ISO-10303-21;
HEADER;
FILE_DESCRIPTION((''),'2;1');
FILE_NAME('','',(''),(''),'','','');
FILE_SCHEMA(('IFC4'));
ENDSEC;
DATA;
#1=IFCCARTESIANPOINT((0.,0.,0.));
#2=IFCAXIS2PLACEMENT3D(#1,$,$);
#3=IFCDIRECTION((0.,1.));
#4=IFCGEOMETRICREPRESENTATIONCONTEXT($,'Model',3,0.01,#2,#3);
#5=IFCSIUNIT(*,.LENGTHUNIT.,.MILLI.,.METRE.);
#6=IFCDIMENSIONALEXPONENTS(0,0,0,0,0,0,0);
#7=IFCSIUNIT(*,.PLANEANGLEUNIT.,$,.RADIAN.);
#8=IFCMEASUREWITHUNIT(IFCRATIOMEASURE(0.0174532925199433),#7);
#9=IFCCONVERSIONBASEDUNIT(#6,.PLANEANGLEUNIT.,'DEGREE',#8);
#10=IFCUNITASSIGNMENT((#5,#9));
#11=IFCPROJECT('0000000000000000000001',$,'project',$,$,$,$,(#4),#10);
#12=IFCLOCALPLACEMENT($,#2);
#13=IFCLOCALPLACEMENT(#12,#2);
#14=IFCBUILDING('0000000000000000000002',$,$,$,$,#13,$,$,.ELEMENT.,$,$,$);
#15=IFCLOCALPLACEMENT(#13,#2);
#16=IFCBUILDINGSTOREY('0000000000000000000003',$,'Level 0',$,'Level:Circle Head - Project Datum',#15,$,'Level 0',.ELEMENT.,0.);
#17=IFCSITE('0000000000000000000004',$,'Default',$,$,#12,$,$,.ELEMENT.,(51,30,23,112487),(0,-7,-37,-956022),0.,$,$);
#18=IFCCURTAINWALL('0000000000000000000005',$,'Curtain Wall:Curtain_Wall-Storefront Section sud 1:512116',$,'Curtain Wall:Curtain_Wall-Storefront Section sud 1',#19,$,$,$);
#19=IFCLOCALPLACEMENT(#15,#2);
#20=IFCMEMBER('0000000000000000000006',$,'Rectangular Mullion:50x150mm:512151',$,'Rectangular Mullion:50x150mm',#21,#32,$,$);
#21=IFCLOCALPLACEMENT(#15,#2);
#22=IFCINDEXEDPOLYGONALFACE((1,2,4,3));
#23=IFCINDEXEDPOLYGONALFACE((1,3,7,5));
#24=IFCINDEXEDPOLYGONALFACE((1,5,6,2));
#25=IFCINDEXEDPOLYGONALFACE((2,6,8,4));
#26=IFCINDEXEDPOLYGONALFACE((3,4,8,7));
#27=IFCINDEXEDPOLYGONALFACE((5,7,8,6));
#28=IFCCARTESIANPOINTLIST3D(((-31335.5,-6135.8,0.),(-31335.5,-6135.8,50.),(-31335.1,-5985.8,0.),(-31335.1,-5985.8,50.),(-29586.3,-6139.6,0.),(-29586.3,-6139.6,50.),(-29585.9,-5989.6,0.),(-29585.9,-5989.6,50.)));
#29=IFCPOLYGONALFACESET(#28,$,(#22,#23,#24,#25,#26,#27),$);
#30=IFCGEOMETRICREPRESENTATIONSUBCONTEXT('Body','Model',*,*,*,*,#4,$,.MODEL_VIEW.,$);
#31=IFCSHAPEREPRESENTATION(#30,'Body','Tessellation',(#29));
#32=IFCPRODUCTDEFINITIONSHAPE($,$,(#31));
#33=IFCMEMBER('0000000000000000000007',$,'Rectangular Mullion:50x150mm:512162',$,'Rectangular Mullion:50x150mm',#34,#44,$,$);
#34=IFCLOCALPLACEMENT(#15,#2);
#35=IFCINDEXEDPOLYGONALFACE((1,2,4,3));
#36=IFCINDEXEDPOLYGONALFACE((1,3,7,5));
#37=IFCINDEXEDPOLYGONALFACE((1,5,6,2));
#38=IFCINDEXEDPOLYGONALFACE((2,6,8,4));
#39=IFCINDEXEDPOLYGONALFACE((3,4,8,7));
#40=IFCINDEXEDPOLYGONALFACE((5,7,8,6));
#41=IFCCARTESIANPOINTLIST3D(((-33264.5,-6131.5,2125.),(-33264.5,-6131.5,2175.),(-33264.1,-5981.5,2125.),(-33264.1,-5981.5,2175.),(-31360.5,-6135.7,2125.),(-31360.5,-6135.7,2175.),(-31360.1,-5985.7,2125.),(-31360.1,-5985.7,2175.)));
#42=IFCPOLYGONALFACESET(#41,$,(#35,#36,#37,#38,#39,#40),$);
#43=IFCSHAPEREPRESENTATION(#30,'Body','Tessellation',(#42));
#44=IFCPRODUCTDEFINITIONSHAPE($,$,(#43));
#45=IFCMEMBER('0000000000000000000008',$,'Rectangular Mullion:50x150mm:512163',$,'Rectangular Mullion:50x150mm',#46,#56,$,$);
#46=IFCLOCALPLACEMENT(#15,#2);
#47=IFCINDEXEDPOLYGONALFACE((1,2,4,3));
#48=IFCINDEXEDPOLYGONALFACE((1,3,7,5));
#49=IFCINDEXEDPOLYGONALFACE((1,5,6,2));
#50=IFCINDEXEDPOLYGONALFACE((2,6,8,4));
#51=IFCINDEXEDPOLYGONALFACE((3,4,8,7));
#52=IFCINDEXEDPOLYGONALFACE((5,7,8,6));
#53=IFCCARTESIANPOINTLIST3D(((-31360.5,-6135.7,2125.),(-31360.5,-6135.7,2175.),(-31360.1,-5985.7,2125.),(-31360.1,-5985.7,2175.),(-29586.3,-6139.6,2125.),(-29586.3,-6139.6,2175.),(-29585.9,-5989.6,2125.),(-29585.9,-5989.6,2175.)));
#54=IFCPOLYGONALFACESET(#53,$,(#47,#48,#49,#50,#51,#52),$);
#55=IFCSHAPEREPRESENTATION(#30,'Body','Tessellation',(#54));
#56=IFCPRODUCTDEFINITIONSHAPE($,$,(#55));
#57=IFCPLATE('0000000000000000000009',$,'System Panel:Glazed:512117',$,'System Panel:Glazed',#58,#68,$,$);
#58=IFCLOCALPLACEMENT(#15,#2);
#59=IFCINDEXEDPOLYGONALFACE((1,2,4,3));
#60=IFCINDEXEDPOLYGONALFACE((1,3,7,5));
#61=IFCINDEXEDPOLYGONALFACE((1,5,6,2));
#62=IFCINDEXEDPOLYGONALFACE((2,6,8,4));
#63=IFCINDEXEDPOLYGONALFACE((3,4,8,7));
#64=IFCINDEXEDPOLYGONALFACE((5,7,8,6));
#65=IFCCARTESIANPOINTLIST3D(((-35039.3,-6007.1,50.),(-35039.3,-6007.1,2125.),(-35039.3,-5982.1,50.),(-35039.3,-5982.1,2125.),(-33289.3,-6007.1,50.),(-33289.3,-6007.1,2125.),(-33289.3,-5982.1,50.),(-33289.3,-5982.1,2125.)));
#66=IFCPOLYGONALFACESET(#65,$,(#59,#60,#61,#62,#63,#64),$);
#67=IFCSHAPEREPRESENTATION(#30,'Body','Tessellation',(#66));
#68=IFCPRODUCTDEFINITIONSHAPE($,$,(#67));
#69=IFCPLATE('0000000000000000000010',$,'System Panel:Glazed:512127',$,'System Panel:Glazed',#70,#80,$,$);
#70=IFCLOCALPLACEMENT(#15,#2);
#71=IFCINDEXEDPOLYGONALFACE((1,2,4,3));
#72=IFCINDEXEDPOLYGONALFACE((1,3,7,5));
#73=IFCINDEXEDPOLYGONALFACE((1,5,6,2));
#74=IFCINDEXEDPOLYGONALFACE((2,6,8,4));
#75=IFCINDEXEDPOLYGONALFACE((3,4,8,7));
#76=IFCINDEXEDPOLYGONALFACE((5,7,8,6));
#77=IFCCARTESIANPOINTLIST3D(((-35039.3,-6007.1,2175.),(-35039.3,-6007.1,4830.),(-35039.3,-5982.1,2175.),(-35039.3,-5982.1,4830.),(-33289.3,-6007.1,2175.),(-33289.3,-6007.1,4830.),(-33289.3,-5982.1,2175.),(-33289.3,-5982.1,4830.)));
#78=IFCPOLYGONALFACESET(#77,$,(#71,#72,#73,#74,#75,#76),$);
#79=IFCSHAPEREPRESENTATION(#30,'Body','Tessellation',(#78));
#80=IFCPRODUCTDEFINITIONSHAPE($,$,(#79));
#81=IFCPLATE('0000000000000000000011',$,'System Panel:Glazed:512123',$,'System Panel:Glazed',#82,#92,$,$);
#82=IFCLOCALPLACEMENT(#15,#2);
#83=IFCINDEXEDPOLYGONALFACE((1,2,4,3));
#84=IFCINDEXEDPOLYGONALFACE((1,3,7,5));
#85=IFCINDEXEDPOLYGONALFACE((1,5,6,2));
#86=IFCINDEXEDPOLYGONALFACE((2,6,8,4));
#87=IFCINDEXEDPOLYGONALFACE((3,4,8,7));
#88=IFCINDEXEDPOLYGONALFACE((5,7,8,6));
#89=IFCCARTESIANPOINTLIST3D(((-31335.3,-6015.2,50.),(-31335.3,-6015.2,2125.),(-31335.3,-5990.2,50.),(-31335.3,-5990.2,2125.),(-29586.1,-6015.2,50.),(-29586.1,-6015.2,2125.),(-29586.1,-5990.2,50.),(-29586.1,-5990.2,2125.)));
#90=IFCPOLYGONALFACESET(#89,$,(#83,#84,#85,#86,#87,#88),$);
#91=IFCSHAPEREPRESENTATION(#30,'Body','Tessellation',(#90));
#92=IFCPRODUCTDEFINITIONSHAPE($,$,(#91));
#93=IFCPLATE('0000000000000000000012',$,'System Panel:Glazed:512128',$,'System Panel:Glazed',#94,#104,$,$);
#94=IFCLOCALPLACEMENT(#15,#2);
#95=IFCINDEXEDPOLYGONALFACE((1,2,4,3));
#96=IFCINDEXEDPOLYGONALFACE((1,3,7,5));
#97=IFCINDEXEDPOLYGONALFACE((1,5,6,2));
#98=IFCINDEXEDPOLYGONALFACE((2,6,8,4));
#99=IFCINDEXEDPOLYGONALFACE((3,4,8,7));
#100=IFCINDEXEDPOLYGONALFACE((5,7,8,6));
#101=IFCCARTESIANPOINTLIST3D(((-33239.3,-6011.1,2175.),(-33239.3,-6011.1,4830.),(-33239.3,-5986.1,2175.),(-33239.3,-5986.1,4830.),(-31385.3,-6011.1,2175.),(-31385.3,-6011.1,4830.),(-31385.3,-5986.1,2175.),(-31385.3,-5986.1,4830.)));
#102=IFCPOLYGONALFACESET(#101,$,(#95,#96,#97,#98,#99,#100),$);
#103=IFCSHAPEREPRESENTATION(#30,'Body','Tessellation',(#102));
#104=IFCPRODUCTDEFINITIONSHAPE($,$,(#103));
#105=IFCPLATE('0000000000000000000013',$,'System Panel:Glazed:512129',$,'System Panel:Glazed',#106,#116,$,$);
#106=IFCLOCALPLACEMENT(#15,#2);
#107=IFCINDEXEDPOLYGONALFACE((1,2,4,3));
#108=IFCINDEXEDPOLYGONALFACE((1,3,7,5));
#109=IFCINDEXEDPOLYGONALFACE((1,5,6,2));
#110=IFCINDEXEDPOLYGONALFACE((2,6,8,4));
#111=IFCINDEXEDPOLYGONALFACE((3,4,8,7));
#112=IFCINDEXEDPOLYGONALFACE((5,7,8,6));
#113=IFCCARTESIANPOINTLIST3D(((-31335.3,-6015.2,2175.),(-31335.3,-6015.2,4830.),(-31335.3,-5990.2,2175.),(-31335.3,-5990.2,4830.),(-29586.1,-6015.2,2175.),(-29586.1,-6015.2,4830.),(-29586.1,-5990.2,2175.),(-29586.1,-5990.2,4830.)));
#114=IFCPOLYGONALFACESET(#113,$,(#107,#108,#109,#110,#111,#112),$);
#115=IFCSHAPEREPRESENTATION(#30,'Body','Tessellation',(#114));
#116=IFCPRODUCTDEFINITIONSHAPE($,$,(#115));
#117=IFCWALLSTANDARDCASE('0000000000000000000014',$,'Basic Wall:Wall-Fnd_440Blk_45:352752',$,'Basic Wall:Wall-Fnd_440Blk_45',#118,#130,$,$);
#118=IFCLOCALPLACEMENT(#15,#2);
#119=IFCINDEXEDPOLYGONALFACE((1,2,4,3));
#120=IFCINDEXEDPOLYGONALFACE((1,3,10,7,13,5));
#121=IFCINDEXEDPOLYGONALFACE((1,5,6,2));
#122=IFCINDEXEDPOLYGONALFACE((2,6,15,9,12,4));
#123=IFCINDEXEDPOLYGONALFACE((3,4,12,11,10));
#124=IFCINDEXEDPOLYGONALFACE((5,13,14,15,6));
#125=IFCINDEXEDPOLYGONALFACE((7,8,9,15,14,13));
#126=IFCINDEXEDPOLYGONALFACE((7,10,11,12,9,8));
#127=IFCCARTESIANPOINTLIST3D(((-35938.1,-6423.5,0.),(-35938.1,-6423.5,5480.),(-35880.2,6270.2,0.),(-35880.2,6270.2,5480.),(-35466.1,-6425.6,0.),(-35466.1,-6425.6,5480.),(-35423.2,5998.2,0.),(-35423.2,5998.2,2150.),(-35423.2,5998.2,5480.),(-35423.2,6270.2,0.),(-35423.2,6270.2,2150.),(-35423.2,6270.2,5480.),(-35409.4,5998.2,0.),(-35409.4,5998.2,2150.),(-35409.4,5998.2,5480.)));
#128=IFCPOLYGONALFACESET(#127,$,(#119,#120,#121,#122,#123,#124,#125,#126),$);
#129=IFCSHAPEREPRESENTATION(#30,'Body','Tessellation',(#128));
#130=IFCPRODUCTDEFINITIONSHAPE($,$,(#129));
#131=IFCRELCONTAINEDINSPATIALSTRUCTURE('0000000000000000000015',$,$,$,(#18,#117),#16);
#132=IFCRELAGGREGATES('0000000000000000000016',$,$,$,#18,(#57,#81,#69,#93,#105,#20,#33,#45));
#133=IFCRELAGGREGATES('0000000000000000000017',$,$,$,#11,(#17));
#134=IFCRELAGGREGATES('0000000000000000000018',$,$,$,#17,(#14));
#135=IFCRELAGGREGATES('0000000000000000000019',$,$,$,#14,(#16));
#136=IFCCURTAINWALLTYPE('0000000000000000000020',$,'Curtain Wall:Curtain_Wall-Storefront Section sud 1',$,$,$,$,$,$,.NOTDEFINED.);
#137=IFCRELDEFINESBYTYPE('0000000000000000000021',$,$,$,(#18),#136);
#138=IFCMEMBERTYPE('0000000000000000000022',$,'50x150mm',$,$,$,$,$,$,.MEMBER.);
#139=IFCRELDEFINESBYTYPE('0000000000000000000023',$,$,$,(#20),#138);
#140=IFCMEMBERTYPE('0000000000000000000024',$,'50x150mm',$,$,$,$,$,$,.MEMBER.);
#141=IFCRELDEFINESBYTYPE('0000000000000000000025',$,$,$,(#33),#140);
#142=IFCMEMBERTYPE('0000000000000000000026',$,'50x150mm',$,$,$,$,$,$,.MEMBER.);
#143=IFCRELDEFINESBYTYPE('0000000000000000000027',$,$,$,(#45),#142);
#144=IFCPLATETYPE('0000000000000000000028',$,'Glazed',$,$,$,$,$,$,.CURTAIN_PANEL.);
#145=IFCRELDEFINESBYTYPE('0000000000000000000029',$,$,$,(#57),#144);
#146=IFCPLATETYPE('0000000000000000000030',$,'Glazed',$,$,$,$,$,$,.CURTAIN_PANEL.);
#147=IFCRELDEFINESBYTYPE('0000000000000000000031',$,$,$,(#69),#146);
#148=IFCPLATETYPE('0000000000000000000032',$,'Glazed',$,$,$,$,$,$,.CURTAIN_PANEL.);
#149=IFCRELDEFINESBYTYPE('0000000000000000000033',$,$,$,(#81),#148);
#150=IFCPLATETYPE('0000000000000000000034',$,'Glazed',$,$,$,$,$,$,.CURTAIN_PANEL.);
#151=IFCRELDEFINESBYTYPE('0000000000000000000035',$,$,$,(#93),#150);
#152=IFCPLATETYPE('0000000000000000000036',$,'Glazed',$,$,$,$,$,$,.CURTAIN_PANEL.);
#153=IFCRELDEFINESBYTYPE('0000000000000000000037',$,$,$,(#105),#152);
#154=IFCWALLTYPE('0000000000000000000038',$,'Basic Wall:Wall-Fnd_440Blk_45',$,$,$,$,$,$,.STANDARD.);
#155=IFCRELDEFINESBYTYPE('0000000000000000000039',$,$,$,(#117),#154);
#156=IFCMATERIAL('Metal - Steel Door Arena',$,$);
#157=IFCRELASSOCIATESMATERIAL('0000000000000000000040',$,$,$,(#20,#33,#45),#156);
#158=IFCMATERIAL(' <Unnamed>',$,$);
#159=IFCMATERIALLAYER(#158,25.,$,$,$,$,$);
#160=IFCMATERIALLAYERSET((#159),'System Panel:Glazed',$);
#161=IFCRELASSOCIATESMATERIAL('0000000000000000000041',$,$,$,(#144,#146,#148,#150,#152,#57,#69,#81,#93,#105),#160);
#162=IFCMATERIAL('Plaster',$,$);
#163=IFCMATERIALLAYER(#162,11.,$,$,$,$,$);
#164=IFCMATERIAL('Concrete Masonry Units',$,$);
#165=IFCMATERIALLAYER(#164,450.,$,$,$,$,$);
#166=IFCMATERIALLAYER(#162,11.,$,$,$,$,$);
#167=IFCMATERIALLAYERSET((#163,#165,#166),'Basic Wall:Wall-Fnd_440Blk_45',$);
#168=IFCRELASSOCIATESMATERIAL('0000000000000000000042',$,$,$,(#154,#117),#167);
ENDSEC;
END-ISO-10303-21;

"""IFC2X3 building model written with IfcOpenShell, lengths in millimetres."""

from ifc_helpers import new_model, entity, si_unit, converted_unit, direction, frame, frame_2d, origin, origin_2d_with_axis, place, context, subcontext, project, spatial, polyline, rectangle, outline, extrude, source, transform, mapped, material, layer, layer_set, layer_usage, type_object, type_shapes, element, aggregate, save


model = new_model("IFC2X3")

# Units and contexts
model_context = context("Model", 3, precision=0.01, world=origin(), true_north=direction((0.0, 1.0)))
body_context = subcontext(model_context, "Body", "Model", "MODEL_VIEW")
ifc_project = project(units=[si_unit("LENGTHUNIT", "METRE", prefix="MILLI"), converted_unit("PLANEANGLEUNIT", "DEGREE", entity("IfcRatioMeasure", 0.0174532925199433), si_unit("PLANEANGLEUNIT", "RADIAN"), dimensions=[0, 0, 0, 0, 0, 0, 0])], contexts=[model_context])

# Site, building, storey
site_placement = place(None, origin())
site = spatial("IfcSite", under=ifc_project, at=site_placement, Name="Default", CompositionType="ELEMENT", RefLatitude=(51, 30, 23, 112487), RefLongitude=(0, -7, -37, -956022), RefElevation=0.0)
building_placement = place(site_placement, origin())
building = spatial("IfcBuilding", under=site, at=building_placement, CompositionType="ELEMENT")
storey_placement = place(building_placement, origin())
storey = spatial("IfcBuildingStorey", under=building, at=storey_placement, Name="Level 0", ObjectType="Level:Circle Head - Project Datum", LongName="Level 0", CompositionType="ELEMENT", Elevation=0.0)

# Curtain wall, members, plates
curtain_wall_type = type_object("IfcCurtainWallType", Name="Curtain Wall:Curtain_Wall-Storefront Section sud 1", PredefinedType="NOTDEFINED")
curtain_wall_placement = place(storey_placement, origin())
curtain_wall = element("IfcCurtainWall", 1, at=curtain_wall_placement, inside=storey, type_object=curtain_wall_type, Name="Curtain Wall:Curtain_Wall-Storefront Section sud 1:512116", ObjectType="Curtain Wall:Curtain_Wall-Storefront Section sud 1")
ifc_material_1 = material(Name="Metal - Steel Door Arena")
member_type_1 = type_object("IfcMemberType", Name="50x150mm", PredefinedType="MEMBER")
shared_shape_1 = source(origin(), body_context, "Body", "SweptSolid", [
    extrude(rectangle(XDim=150.0, YDim=50.0, at=origin_2d_with_axis()), frame((-25.0, 0.0, -1749.2), z_axis=(0.0, 0.0, 1.0), x_axis=(0.0, -1.0, 0.0)), (0.0, 0.0, 1.0), 1749.2),
])
type_shapes(member_type_1, [shared_shape_1])
member_1_placement = place(storey_placement, frame((-31335.3, -6060.8, 0.0), z_axis=(-0.999998, 0.002199, 0.0), x_axis=(0.0, 0.0, -1.0)))
member_1 = element("IfcMember", 2, at=member_1_placement, type_object=member_type_1, material=ifc_material_1, Name="Rectangular Mullion:50x150mm:512151", ObjectType="Rectangular Mullion:50x150mm", context=body_context, shape_type="MappedRepresentation", body=[
    mapped(shared_shape_1, transform((0.0, 0.0, 0.0), scale=1.0)),
])
member_type_2 = type_object("IfcMemberType", Name="50x150mm", PredefinedType="MEMBER")
shared_shape_2 = source(origin(), body_context, "Body", "SweptSolid", [
    extrude(rectangle(XDim=150.0, YDim=50.0, at=origin_2d_with_axis()), frame((0.0, 0.0, -1904.0), z_axis=(0.0, 0.0, 1.0), x_axis=(0.0, -1.0, 0.0)), (0.0, 0.0, 1.0), 1904.0),
])
type_shapes(member_type_2, [shared_shape_2])
member_2_placement = place(storey_placement, frame((-31360.3, -6060.7, 2150.0), z_axis=(0.999998, -0.002199, 0.0), x_axis=(0.0, 0.0, 1.0)))
member_2 = element("IfcMember", 3, at=member_2_placement, type_object=member_type_2, material=ifc_material_1, Name="Rectangular Mullion:50x150mm:512162", ObjectType="Rectangular Mullion:50x150mm", context=body_context, shape_type="MappedRepresentation", body=[
    mapped(shared_shape_2, transform((0.0, 0.0, 0.0), scale=1.0)),
])
member_type_3 = type_object("IfcMemberType", Name="50x150mm", PredefinedType="MEMBER")
shared_shape_3 = source(origin(), body_context, "Body", "SweptSolid", [
    extrude(rectangle(XDim=150.0, YDim=50.0, at=origin_2d_with_axis()), frame((0.0, 0.0, -1774.2), z_axis=(0.0, 0.0, 1.0), x_axis=(0.0, -1.0, 0.0)), (0.0, 0.0, 1.0), 1774.2),
])
type_shapes(member_type_3, [shared_shape_3])
member_3_placement = place(storey_placement, frame((-29586.1, -6064.6, 2150.0), z_axis=(0.999998, -0.002199, 0.0), x_axis=(0.0, 0.0, 1.0)))
member_3 = element("IfcMember", 4, at=member_3_placement, type_object=member_type_3, material=ifc_material_1, Name="Rectangular Mullion:50x150mm:512163", ObjectType="Rectangular Mullion:50x150mm", context=body_context, shape_type="MappedRepresentation", body=[
    mapped(shared_shape_3, transform((0.0, 0.0, 0.0), scale=1.0)),
])
ifc_material_2 = material(Name=" <Unnamed>")
ifc_layer_1 = layer(ifc_material_2, 25.0)
ifc_layer_set_1 = layer_set([ifc_layer_1], Name="System Panel:Glazed")
ifc_layer_usage_1 = layer_usage(ifc_layer_set_1, "AXIS3", "POSITIVE", 0.2)
plate_type_1 = type_object("IfcPlateType", Name="Glazed", PredefinedType="CURTAIN_PANEL", material=ifc_layer_set_1)
shared_shape_4 = source(origin(), body_context, "Body", "SweptSolid", [
    extrude(rectangle(XDim=25.0, YDim=1750.0, at=origin_2d_with_axis()), frame((0.0, 60.0, 0.0), z_axis=(0.0, 0.0, 1.0), x_axis=(0.0, 1.0, 0.0)), (0.0, 0.0, 1.0), 2075.0),
])
type_shapes(plate_type_1, [shared_shape_4])
plate_1_placement = place(curtain_wall_placement, frame((-34164.3, -6054.6, 50.0)))
plate_1 = element("IfcPlate", 5, at=plate_1_placement, type_object=plate_type_1, material=ifc_layer_usage_1, Name="System Panel:Glazed:512117", ObjectType="System Panel:Glazed", context=body_context, shape_type="MappedRepresentation", body=[
    mapped(shared_shape_4, transform((0.0, 0.0, 0.0), scale=1.0)),
])
ifc_layer_usage_2 = layer_usage(ifc_layer_set_1, "AXIS3", "POSITIVE", 0.2)
plate_type_2 = type_object("IfcPlateType", Name="Glazed", PredefinedType="CURTAIN_PANEL", material=ifc_layer_set_1)
shared_shape_5 = source(origin(), body_context, "Body", "SweptSolid", [
    extrude(rectangle(XDim=25.0, YDim=1750.0, at=frame_2d((0.0, 0.0), x_axis=(1.0, 0.0))), frame((0.0, 60.0, 0.0), z_axis=(0.0, 0.0, 1.0), x_axis=(0.0, 1.0, 0.0)), (0.0, 0.0, 1.0), 2655.0),
])
type_shapes(plate_type_2, [shared_shape_5])
plate_2_placement = place(curtain_wall_placement, frame((-34164.3, -6054.6, 2175.0)))
plate_2 = element("IfcPlate", 6, at=plate_2_placement, type_object=plate_type_2, material=ifc_layer_usage_2, Name="System Panel:Glazed:512127", ObjectType="System Panel:Glazed", context=body_context, shape_type="MappedRepresentation", body=[
    mapped(shared_shape_5, transform((0.0, 0.0, 0.0), scale=1.0)),
])
ifc_layer_usage_3 = layer_usage(ifc_layer_set_1, "AXIS3", "POSITIVE", 0.2)
plate_type_3 = type_object("IfcPlateType", Name="Glazed", PredefinedType="CURTAIN_PANEL", material=ifc_layer_set_1)
shared_shape_6 = source(origin(), body_context, "Body", "SweptSolid", [
    extrude(rectangle(XDim=25.0, YDim=1749.2, at=origin_2d_with_axis()), frame((0.0, 60.0, 0.0), z_axis=(0.0, 0.0, 1.0), x_axis=(0.0, 1.0, 0.0)), (0.0, 0.0, 1.0), 2075.0),
])
type_shapes(plate_type_3, [shared_shape_6])
plate_3_placement = place(curtain_wall_placement, frame((-30460.7, -6062.7, 50.0)))
plate_3 = element("IfcPlate", 7, at=plate_3_placement, type_object=plate_type_3, material=ifc_layer_usage_3, Name="System Panel:Glazed:512123", ObjectType="System Panel:Glazed", context=body_context, shape_type="MappedRepresentation", body=[
    mapped(shared_shape_6, transform((0.0, 0.0, 0.0), scale=1.0)),
])
ifc_layer_usage_4 = layer_usage(ifc_layer_set_1, "AXIS3", "POSITIVE", 0.2)
plate_type_4 = type_object("IfcPlateType", Name="Glazed", PredefinedType="CURTAIN_PANEL", material=ifc_layer_set_1)
shared_shape_7 = source(origin(), body_context, "Body", "SweptSolid", [
    extrude(rectangle(XDim=25.0, YDim=1854.0, at=frame_2d((0.0, 0.0), x_axis=(1.0, 0.0))), frame((0.0, 60.0, 0.0), z_axis=(0.0, 0.0, 1.0), x_axis=(0.0, 1.0, 0.0)), (0.0, 0.0, 1.0), 2655.0),
])
type_shapes(plate_type_4, [shared_shape_7])
plate_4_placement = place(curtain_wall_placement, frame((-32312.3, -6058.6, 2175.0)))
plate_4 = element("IfcPlate", 8, at=plate_4_placement, type_object=plate_type_4, material=ifc_layer_usage_4, Name="System Panel:Glazed:512128", ObjectType="System Panel:Glazed", context=body_context, shape_type="MappedRepresentation", body=[
    mapped(shared_shape_7, transform((0.0, 0.0, 0.0), scale=1.0)),
])
ifc_layer_usage_5 = layer_usage(ifc_layer_set_1, "AXIS3", "POSITIVE", 0.2)
plate_type_5 = type_object("IfcPlateType", Name="Glazed", PredefinedType="CURTAIN_PANEL", material=ifc_layer_set_1)
shared_shape_8 = source(origin(), body_context, "Body", "SweptSolid", [
    extrude(rectangle(XDim=25.0, YDim=1749.2, at=frame_2d((0.0, 0.0), x_axis=(1.0, 0.0))), frame((0.0, 60.0, 0.0), z_axis=(0.0, 0.0, 1.0), x_axis=(0.0, 1.0, 0.0)), (0.0, 0.0, 1.0), 2655.0),
])
type_shapes(plate_type_5, [shared_shape_8])
plate_5_placement = place(curtain_wall_placement, frame((-30460.7, -6062.7, 2175.0)))
plate_5 = element("IfcPlate", 9, at=plate_5_placement, type_object=plate_type_5, material=ifc_layer_usage_5, Name="System Panel:Glazed:512129", ObjectType="System Panel:Glazed", context=body_context, shape_type="MappedRepresentation", body=[
    mapped(shared_shape_8, transform((0.0, 0.0, 0.0), scale=1.0)),
])
aggregate(curtain_wall, [plate_1, plate_3, plate_2, plate_4, plate_5, member_1, member_2, member_3])

# Wall, opening
ifc_material_3 = material(Name="Plaster")
ifc_layer_2 = layer(ifc_material_3, 11.0)
ifc_material_4 = material(Name="Concrete Masonry Units")
ifc_layer_3 = layer(ifc_material_4, 450.0)
ifc_layer_4 = layer(ifc_material_3, 11.0)
ifc_layer_set_2 = layer_set([ifc_layer_2, ifc_layer_3, ifc_layer_4], Name="Basic Wall:Wall-Fnd_440Blk_45")
ifc_layer_usage_6 = layer_usage(ifc_layer_set_2, "AXIS2", "NEGATIVE", 236.0)
wall_type = type_object("IfcWallType", Name="Basic Wall:Wall-Fnd_440Blk_45", PredefinedType="STANDARD", material=ifc_layer_set_2)
wall_placement = place(storey_placement, frame((-35644.2, 6271.3, 0.0), z_axis=(0.0, 0.0, 1.0), x_axis=(-0.004561, -0.99999, 0.0)))
wall = element("IfcWallStandardCase", 10, at=wall_placement, inside=storey, type_object=wall_type, material=ifc_layer_usage_6, Name="Basic Wall:Wall-Fnd_440Blk_45:352752", ObjectType="Basic Wall:Wall-Fnd_440Blk_45", context=body_context, shape_type="SweptSolid", body=[
    extrude(outline(polyline([(12696.0, -236.0), (12696.0, 236.0), (12611.6, 236.0), (12247.1, 236.0), (272.0, 236.0), (272.1, 222.2), (0.1, 221.0), (2.2, -236.0), (12696.0, -236.0)])), origin(), (0.0, 0.0, 1.0), 5480.0),
])
opening_placement = place(wall_placement, origin())
element("IfcOpeningElement", 11, at=opening_placement, cuts=wall, ObjectType="Opening", context=body_context, shape_type="SweptSolid", body=[
    extrude(rectangle(XDim=2150.0, YDim=272.0, at=frame_2d((0.0, 0.0), x_axis=(0.0, 1.0))), frame((136.1, 221.6, 1075.0), z_axis=(-0.004561, 0.99999, 0.0), x_axis=(-0.99999, -0.004561, 0.0)), (0.0, 0.0, 1.0), 1600.0),
])

save(model, "model.ifc")
